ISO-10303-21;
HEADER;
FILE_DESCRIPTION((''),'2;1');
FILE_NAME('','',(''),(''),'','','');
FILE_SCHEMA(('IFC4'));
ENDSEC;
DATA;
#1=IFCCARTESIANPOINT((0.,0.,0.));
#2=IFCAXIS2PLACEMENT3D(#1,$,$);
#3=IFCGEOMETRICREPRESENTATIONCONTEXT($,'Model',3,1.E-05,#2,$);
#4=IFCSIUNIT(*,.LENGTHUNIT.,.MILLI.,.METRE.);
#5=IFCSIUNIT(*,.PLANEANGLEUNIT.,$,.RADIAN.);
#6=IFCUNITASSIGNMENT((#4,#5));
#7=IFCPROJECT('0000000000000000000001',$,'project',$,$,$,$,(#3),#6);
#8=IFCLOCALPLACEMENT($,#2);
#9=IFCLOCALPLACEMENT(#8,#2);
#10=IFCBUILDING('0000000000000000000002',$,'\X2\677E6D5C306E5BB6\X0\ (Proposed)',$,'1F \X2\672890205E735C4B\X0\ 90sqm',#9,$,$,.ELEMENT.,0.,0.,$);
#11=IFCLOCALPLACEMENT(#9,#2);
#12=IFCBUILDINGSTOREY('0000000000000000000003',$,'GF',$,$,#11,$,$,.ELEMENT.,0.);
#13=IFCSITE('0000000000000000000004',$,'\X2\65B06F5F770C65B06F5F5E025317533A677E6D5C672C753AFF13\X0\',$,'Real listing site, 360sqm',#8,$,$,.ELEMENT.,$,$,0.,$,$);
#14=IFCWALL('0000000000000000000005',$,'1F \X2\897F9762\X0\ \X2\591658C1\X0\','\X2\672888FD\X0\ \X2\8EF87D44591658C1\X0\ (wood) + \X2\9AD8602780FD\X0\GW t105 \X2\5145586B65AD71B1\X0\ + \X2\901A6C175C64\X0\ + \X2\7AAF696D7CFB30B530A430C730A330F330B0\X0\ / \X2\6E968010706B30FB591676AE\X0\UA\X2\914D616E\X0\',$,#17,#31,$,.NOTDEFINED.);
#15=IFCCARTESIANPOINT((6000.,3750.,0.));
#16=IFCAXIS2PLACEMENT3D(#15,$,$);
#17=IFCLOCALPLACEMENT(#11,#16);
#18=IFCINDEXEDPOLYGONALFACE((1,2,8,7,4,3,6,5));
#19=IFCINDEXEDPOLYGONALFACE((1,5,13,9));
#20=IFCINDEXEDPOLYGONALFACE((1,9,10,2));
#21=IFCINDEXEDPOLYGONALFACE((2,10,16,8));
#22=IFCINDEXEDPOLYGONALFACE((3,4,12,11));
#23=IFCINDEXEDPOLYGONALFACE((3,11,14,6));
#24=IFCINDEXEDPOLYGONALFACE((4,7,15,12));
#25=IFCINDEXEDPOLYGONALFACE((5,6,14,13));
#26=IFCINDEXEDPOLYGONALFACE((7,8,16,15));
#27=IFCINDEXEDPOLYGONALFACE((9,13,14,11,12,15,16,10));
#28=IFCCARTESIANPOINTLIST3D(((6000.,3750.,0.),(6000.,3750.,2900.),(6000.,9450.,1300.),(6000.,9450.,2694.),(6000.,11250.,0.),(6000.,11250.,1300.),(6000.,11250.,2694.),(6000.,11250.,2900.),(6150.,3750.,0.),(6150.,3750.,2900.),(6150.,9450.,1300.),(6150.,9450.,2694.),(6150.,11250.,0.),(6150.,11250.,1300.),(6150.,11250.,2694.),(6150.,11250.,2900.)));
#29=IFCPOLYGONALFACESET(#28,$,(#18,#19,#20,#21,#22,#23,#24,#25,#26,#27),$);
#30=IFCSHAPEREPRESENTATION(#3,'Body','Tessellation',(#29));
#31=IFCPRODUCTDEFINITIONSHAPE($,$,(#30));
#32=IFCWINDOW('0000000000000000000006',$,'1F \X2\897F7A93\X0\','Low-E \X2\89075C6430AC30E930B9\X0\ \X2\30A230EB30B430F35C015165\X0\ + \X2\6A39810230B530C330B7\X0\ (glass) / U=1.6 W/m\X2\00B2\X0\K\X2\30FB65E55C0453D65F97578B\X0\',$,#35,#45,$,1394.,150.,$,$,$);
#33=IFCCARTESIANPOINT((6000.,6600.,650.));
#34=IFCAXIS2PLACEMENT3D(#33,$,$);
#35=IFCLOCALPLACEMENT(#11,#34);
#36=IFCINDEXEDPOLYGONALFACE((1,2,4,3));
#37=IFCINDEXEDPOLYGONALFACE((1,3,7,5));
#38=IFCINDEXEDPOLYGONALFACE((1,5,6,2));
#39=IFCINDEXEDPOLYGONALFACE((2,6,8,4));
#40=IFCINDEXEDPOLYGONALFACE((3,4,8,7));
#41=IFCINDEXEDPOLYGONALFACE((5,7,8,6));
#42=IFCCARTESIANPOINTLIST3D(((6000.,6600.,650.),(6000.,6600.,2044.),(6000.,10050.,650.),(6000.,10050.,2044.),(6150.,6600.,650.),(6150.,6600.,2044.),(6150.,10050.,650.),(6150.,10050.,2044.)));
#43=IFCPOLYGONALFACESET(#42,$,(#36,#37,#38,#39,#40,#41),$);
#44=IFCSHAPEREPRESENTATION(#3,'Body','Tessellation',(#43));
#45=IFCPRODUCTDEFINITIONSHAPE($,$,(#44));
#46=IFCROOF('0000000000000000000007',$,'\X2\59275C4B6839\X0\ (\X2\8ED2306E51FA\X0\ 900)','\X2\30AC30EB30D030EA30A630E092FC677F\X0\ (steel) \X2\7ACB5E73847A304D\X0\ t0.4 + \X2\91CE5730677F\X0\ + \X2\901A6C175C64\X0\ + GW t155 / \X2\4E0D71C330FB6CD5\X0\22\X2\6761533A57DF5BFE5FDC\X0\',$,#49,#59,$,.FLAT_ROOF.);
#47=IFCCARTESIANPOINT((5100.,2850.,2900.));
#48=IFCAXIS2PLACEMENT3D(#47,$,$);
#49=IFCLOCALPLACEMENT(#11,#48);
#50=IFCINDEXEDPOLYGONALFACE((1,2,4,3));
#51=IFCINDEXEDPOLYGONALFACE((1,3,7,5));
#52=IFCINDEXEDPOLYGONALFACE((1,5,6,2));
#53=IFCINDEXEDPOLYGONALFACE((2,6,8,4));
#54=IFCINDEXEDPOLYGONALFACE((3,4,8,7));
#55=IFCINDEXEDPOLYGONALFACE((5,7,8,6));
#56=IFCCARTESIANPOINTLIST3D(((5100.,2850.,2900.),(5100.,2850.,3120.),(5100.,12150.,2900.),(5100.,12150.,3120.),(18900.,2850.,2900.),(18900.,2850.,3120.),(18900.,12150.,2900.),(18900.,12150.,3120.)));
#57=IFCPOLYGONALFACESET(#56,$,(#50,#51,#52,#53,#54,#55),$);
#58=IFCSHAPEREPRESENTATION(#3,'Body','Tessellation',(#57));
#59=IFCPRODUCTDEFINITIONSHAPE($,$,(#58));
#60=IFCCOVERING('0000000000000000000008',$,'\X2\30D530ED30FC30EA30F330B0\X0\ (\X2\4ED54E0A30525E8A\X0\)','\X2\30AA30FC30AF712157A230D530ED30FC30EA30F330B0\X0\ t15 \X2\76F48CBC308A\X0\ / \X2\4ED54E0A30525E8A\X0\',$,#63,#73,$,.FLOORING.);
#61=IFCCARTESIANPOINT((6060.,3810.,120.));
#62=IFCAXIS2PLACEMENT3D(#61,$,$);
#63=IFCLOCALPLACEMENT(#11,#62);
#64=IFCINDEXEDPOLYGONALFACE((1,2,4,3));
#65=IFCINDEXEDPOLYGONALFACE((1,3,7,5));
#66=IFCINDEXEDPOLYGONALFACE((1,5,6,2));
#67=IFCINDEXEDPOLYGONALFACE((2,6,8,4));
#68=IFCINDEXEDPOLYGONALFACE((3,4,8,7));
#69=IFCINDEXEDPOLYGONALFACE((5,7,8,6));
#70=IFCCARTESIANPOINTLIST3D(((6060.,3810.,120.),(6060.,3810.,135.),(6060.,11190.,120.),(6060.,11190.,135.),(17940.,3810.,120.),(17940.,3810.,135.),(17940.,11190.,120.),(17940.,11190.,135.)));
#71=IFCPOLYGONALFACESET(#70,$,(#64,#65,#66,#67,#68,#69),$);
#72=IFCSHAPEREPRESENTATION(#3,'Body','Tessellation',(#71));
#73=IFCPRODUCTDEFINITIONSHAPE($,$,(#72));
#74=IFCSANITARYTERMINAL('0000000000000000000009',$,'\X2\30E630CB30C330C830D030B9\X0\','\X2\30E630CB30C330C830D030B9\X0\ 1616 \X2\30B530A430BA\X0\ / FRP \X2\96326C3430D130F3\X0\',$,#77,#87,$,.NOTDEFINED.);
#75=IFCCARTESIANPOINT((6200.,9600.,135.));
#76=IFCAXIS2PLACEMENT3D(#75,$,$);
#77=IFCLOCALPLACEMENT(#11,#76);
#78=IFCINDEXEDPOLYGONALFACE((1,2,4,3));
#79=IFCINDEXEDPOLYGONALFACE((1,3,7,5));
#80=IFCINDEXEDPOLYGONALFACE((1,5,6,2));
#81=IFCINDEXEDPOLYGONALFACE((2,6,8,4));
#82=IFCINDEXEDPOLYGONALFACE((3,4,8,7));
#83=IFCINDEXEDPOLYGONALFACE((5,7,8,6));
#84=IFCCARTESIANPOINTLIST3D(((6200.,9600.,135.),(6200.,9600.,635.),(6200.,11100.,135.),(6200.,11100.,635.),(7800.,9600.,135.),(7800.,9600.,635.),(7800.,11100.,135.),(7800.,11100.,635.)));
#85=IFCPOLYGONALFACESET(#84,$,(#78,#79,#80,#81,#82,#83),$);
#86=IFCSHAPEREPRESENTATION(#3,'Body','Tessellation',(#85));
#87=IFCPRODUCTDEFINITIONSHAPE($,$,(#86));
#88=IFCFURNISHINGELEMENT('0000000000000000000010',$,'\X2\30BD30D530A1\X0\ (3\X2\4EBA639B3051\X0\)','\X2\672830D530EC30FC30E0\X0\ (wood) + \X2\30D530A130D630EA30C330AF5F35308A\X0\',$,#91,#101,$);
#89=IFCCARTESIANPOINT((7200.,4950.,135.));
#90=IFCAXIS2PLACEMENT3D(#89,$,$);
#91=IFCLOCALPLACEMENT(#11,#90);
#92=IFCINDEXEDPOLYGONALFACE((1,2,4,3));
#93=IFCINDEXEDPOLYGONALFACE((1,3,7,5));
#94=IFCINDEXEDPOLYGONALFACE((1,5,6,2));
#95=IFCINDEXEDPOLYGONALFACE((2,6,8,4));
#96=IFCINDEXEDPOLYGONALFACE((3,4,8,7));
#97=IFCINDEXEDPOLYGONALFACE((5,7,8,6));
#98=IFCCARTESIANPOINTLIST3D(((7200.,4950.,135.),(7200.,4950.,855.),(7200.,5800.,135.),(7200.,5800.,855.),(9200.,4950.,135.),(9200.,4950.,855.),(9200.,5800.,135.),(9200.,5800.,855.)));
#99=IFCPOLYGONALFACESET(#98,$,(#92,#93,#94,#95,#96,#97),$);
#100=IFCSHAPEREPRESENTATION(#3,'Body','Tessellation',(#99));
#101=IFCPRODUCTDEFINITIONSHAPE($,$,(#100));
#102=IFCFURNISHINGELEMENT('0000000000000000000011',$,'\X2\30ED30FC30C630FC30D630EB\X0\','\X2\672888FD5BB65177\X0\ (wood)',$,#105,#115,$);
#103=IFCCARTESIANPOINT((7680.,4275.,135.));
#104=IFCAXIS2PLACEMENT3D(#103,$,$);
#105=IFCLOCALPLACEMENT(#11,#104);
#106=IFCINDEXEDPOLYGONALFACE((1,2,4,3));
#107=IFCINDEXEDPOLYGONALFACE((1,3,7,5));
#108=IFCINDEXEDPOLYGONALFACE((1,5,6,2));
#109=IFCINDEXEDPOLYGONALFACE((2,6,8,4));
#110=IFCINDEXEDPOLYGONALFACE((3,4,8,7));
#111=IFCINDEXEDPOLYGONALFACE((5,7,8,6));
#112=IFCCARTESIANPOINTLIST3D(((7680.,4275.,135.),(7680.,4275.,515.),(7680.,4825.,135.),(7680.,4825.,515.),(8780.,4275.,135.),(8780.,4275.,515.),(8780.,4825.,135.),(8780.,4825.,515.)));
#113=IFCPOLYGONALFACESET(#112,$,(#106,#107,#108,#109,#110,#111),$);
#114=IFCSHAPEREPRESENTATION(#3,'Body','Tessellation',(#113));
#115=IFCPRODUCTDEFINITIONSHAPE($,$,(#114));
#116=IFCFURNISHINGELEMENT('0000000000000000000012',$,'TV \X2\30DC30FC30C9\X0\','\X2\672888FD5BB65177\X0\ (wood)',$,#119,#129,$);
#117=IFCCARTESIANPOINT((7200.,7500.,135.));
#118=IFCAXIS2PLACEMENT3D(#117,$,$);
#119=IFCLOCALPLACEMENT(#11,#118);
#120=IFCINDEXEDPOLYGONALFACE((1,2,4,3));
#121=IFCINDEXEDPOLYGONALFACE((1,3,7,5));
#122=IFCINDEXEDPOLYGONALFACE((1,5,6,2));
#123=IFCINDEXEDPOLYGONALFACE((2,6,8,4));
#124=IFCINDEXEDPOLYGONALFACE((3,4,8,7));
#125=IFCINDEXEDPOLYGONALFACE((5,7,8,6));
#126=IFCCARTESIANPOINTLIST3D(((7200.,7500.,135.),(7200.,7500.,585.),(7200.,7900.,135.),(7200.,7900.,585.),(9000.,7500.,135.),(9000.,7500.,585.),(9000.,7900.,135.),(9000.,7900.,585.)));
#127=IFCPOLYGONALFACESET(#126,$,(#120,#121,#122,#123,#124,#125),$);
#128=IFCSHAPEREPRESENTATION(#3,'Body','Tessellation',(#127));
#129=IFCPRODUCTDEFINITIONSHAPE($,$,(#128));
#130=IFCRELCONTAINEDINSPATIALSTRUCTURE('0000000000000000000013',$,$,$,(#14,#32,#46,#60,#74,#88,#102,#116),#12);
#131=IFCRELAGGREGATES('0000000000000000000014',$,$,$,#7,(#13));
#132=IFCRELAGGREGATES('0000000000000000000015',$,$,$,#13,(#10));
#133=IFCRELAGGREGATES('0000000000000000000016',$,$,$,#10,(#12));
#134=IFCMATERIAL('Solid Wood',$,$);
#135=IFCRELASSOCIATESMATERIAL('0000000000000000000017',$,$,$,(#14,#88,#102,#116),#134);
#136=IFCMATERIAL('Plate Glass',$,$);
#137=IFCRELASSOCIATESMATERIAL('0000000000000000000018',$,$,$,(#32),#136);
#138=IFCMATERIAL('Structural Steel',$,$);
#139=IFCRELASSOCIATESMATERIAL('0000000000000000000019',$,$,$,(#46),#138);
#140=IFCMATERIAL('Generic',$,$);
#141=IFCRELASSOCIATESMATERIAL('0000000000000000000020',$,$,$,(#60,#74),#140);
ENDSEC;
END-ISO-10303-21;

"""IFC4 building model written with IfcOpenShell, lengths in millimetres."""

from ifc_helpers import new_model, si_unit, frame, frame_2d, origin, place, context, project, spatial, rectangle, extrude, material, element, fill, save


model = new_model("IFC4")

# Units and contexts
model_context = context("Model", 3, precision=1e-05, world=origin())
ifc_project = project(units=[si_unit("LENGTHUNIT", "METRE", prefix="MILLI"), si_unit("PLANEANGLEUNIT", "RADIAN")], contexts=[model_context])

# Site, building, storey
site_placement = place(None, origin())
site = spatial("IfcSite", under=ifc_project, at=site_placement, Name="新潟県新潟市北区松浜本町３", ObjectType="Real listing site, 360sqm", CompositionType="ELEMENT", RefElevation=0.0)
building_placement = place(site_placement, origin())
building = spatial("IfcBuilding", under=site, at=building_placement, Name="松浜の家 (Proposed)", ObjectType="1F 木造平屋 90sqm", CompositionType="ELEMENT", ElevationOfRefHeight=0.0, ElevationOfTerrain=0.0)
storey_placement = place(building_placement, origin())
storey = spatial("IfcBuildingStorey", under=building, at=storey_placement, Name="GF", CompositionType="ELEMENT", Elevation=0.0)

# Shared definitions
ifc_material_1 = material(Name="Solid Wood")

# Shared definitions
ifc_material_2 = material(Name="Plate Glass")

# Wall, opening, window
wall_1_placement = place(storey_placement, frame((6000.0, 3750.0, 0.0)))
wall_1 = element("IfcWall", 1, at=wall_1_placement, inside=storey, material=ifc_material_1, Name="1F 西面 外壁", Description="木製 軸組外壁 (wood) + 高性能GW t105 充填断熱 + 通気層 + 窯業系サイディング / 準耐火・外皮UA配慮", PredefinedType="NOTDEFINED", context=model_context, shape_type="SweptSolid", body=[
    extrude(rectangle(XDim=150.0, YDim=7500.0, at=frame_2d((75.0, 3750.0))), frame((6000.0, 3750.0, 0.0)), (0.0, 0.0, 1.0), 2900.0),
])
opening_1_placement = place(storey_placement, frame((6000.0, 6600.0, 650.0)))
opening_1 = element("IfcOpeningElement", 2, at=opening_1_placement, cuts=wall_1, PredefinedType="NOTDEFINED", context=model_context, shape_type="SweptSolid", body=[
    extrude(rectangle(XDim=150.0, YDim=3450.0, at=frame_2d((75.0, 1725.0))), frame((6000.0, 6600.0, 650.0)), (0.0, 0.0, 1.0), 1394.0),
])
window_1_placement = place(storey_placement, frame((6000.0, 6600.0, 650.0)))
window_1 = element("IfcWindow", 3, at=window_1_placement, inside=storey, material=ifc_material_2, Name="1F 西窓", Description="Low-E 複層ガラス アルゴン封入 + 樹脂サッシ (glass) / U=1.6 W/m²K・日射取得型", OverallHeight=1394.0, OverallWidth=150.0, context=model_context, shape_type="SweptSolid", body=[
    extrude(rectangle(XDim=150.0, YDim=3450.0, at=frame_2d((75.0, 1725.0))), frame((6000.0, 6600.0, 650.0)), (0.0, 0.0, 1.0), 1394.0),
])
fill(opening_1, window_1)

# Roof
ifc_material_3 = material(Name="Structural Steel")
roof_placement = place(storey_placement, frame((5100.0, 2850.0, 2900.0)))
element("IfcRoof", 4, at=roof_placement, inside=storey, material=ifc_material_3, Name="大屋根 (軒の出 900)", Description="ガルバリウム鋼板 (steel) 立平葺き t0.4 + 野地板 + 通気層 + GW t155 / 不燃・法22条区域対応", PredefinedType="FLAT_ROOF", context=model_context, shape_type="SweptSolid", body=[
    extrude(rectangle(XDim=13800.0, YDim=9300.0, at=frame_2d((6900.0, 4650.0))), frame((5100.0, 2850.0, 2900.0)), (0.0, 0.0, 1.0), 220.0),
])

# Covering
ifc_material_4 = material(Name="Generic")
covering_placement = place(storey_placement, frame((6060.0, 3810.0, 120.0)))
element("IfcCovering", 5, at=covering_placement, inside=storey, material=ifc_material_4, Name="フローリング (仕上げ床)", Description="オーク無垢フローリング t15 直貼り / 仕上げ床", PredefinedType="FLOORING", context=model_context, shape_type="SweptSolid", body=[
    extrude(rectangle(XDim=11880.0, YDim=7380.0, at=frame_2d((5940.0, 3690.0))), frame((6060.0, 3810.0, 120.0)), (0.0, 0.0, 1.0), 15.0),
])

# Sanitary terminal
sanitary_terminal_placement = place(storey_placement, frame((6200.0, 9600.0, 135.0)))
element("IfcSanitaryTerminal", 6, at=sanitary_terminal_placement, inside=storey, material=ifc_material_4, Name="ユニットバス", Description="ユニットバス 1616 サイズ / FRP 防水パン", PredefinedType="NOTDEFINED", context=model_context, shape_type="SweptSolid", body=[
    extrude(rectangle(XDim=1600.0, YDim=1500.0, at=frame_2d((800.0, 750.0))), frame((6200.0, 9600.0, 135.0)), (0.0, 0.0, 1.0), 500.0),
])

# Furnishing elements
furnishing_1_placement = place(storey_placement, frame((7200.0, 4950.0, 135.0)))
element("IfcFurnishingElement", 7, at=furnishing_1_placement, inside=storey, material=ifc_material_1, Name="ソファ (3人掛け)", Description="木フレーム (wood) + ファブリック張り", context=model_context, shape_type="SweptSolid", body=[
    extrude(rectangle(XDim=2000.0, YDim=850.0, at=frame_2d((1000.0, 425.0))), frame((7200.0, 4950.0, 135.0)), (0.0, 0.0, 1.0), 720.0),
])
furnishing_2_placement = place(storey_placement, frame((7680.0, 4275.0, 135.0)))
element("IfcFurnishingElement", 8, at=furnishing_2_placement, inside=storey, material=ifc_material_1, Name="ローテーブル", Description="木製家具 (wood)", context=model_context, shape_type="SweptSolid", body=[
    extrude(rectangle(XDim=1100.0, YDim=550.0, at=frame_2d((550.0, 275.0))), frame((7680.0, 4275.0, 135.0)), (0.0, 0.0, 1.0), 380.0),
])
furnishing_3_placement = place(storey_placement, frame((7200.0, 7500.0, 135.0)))
element("IfcFurnishingElement", 9, at=furnishing_3_placement, inside=storey, material=ifc_material_1, Name="TV ボード", Description="木製家具 (wood)", context=model_context, shape_type="SweptSolid", body=[
    extrude(rectangle(XDim=1800.0, YDim=400.0, at=frame_2d((900.0, 200.0))), frame((7200.0, 7500.0, 135.0)), (0.0, 0.0, 1.0), 450.0),
])

save(model, "model.ifc")
